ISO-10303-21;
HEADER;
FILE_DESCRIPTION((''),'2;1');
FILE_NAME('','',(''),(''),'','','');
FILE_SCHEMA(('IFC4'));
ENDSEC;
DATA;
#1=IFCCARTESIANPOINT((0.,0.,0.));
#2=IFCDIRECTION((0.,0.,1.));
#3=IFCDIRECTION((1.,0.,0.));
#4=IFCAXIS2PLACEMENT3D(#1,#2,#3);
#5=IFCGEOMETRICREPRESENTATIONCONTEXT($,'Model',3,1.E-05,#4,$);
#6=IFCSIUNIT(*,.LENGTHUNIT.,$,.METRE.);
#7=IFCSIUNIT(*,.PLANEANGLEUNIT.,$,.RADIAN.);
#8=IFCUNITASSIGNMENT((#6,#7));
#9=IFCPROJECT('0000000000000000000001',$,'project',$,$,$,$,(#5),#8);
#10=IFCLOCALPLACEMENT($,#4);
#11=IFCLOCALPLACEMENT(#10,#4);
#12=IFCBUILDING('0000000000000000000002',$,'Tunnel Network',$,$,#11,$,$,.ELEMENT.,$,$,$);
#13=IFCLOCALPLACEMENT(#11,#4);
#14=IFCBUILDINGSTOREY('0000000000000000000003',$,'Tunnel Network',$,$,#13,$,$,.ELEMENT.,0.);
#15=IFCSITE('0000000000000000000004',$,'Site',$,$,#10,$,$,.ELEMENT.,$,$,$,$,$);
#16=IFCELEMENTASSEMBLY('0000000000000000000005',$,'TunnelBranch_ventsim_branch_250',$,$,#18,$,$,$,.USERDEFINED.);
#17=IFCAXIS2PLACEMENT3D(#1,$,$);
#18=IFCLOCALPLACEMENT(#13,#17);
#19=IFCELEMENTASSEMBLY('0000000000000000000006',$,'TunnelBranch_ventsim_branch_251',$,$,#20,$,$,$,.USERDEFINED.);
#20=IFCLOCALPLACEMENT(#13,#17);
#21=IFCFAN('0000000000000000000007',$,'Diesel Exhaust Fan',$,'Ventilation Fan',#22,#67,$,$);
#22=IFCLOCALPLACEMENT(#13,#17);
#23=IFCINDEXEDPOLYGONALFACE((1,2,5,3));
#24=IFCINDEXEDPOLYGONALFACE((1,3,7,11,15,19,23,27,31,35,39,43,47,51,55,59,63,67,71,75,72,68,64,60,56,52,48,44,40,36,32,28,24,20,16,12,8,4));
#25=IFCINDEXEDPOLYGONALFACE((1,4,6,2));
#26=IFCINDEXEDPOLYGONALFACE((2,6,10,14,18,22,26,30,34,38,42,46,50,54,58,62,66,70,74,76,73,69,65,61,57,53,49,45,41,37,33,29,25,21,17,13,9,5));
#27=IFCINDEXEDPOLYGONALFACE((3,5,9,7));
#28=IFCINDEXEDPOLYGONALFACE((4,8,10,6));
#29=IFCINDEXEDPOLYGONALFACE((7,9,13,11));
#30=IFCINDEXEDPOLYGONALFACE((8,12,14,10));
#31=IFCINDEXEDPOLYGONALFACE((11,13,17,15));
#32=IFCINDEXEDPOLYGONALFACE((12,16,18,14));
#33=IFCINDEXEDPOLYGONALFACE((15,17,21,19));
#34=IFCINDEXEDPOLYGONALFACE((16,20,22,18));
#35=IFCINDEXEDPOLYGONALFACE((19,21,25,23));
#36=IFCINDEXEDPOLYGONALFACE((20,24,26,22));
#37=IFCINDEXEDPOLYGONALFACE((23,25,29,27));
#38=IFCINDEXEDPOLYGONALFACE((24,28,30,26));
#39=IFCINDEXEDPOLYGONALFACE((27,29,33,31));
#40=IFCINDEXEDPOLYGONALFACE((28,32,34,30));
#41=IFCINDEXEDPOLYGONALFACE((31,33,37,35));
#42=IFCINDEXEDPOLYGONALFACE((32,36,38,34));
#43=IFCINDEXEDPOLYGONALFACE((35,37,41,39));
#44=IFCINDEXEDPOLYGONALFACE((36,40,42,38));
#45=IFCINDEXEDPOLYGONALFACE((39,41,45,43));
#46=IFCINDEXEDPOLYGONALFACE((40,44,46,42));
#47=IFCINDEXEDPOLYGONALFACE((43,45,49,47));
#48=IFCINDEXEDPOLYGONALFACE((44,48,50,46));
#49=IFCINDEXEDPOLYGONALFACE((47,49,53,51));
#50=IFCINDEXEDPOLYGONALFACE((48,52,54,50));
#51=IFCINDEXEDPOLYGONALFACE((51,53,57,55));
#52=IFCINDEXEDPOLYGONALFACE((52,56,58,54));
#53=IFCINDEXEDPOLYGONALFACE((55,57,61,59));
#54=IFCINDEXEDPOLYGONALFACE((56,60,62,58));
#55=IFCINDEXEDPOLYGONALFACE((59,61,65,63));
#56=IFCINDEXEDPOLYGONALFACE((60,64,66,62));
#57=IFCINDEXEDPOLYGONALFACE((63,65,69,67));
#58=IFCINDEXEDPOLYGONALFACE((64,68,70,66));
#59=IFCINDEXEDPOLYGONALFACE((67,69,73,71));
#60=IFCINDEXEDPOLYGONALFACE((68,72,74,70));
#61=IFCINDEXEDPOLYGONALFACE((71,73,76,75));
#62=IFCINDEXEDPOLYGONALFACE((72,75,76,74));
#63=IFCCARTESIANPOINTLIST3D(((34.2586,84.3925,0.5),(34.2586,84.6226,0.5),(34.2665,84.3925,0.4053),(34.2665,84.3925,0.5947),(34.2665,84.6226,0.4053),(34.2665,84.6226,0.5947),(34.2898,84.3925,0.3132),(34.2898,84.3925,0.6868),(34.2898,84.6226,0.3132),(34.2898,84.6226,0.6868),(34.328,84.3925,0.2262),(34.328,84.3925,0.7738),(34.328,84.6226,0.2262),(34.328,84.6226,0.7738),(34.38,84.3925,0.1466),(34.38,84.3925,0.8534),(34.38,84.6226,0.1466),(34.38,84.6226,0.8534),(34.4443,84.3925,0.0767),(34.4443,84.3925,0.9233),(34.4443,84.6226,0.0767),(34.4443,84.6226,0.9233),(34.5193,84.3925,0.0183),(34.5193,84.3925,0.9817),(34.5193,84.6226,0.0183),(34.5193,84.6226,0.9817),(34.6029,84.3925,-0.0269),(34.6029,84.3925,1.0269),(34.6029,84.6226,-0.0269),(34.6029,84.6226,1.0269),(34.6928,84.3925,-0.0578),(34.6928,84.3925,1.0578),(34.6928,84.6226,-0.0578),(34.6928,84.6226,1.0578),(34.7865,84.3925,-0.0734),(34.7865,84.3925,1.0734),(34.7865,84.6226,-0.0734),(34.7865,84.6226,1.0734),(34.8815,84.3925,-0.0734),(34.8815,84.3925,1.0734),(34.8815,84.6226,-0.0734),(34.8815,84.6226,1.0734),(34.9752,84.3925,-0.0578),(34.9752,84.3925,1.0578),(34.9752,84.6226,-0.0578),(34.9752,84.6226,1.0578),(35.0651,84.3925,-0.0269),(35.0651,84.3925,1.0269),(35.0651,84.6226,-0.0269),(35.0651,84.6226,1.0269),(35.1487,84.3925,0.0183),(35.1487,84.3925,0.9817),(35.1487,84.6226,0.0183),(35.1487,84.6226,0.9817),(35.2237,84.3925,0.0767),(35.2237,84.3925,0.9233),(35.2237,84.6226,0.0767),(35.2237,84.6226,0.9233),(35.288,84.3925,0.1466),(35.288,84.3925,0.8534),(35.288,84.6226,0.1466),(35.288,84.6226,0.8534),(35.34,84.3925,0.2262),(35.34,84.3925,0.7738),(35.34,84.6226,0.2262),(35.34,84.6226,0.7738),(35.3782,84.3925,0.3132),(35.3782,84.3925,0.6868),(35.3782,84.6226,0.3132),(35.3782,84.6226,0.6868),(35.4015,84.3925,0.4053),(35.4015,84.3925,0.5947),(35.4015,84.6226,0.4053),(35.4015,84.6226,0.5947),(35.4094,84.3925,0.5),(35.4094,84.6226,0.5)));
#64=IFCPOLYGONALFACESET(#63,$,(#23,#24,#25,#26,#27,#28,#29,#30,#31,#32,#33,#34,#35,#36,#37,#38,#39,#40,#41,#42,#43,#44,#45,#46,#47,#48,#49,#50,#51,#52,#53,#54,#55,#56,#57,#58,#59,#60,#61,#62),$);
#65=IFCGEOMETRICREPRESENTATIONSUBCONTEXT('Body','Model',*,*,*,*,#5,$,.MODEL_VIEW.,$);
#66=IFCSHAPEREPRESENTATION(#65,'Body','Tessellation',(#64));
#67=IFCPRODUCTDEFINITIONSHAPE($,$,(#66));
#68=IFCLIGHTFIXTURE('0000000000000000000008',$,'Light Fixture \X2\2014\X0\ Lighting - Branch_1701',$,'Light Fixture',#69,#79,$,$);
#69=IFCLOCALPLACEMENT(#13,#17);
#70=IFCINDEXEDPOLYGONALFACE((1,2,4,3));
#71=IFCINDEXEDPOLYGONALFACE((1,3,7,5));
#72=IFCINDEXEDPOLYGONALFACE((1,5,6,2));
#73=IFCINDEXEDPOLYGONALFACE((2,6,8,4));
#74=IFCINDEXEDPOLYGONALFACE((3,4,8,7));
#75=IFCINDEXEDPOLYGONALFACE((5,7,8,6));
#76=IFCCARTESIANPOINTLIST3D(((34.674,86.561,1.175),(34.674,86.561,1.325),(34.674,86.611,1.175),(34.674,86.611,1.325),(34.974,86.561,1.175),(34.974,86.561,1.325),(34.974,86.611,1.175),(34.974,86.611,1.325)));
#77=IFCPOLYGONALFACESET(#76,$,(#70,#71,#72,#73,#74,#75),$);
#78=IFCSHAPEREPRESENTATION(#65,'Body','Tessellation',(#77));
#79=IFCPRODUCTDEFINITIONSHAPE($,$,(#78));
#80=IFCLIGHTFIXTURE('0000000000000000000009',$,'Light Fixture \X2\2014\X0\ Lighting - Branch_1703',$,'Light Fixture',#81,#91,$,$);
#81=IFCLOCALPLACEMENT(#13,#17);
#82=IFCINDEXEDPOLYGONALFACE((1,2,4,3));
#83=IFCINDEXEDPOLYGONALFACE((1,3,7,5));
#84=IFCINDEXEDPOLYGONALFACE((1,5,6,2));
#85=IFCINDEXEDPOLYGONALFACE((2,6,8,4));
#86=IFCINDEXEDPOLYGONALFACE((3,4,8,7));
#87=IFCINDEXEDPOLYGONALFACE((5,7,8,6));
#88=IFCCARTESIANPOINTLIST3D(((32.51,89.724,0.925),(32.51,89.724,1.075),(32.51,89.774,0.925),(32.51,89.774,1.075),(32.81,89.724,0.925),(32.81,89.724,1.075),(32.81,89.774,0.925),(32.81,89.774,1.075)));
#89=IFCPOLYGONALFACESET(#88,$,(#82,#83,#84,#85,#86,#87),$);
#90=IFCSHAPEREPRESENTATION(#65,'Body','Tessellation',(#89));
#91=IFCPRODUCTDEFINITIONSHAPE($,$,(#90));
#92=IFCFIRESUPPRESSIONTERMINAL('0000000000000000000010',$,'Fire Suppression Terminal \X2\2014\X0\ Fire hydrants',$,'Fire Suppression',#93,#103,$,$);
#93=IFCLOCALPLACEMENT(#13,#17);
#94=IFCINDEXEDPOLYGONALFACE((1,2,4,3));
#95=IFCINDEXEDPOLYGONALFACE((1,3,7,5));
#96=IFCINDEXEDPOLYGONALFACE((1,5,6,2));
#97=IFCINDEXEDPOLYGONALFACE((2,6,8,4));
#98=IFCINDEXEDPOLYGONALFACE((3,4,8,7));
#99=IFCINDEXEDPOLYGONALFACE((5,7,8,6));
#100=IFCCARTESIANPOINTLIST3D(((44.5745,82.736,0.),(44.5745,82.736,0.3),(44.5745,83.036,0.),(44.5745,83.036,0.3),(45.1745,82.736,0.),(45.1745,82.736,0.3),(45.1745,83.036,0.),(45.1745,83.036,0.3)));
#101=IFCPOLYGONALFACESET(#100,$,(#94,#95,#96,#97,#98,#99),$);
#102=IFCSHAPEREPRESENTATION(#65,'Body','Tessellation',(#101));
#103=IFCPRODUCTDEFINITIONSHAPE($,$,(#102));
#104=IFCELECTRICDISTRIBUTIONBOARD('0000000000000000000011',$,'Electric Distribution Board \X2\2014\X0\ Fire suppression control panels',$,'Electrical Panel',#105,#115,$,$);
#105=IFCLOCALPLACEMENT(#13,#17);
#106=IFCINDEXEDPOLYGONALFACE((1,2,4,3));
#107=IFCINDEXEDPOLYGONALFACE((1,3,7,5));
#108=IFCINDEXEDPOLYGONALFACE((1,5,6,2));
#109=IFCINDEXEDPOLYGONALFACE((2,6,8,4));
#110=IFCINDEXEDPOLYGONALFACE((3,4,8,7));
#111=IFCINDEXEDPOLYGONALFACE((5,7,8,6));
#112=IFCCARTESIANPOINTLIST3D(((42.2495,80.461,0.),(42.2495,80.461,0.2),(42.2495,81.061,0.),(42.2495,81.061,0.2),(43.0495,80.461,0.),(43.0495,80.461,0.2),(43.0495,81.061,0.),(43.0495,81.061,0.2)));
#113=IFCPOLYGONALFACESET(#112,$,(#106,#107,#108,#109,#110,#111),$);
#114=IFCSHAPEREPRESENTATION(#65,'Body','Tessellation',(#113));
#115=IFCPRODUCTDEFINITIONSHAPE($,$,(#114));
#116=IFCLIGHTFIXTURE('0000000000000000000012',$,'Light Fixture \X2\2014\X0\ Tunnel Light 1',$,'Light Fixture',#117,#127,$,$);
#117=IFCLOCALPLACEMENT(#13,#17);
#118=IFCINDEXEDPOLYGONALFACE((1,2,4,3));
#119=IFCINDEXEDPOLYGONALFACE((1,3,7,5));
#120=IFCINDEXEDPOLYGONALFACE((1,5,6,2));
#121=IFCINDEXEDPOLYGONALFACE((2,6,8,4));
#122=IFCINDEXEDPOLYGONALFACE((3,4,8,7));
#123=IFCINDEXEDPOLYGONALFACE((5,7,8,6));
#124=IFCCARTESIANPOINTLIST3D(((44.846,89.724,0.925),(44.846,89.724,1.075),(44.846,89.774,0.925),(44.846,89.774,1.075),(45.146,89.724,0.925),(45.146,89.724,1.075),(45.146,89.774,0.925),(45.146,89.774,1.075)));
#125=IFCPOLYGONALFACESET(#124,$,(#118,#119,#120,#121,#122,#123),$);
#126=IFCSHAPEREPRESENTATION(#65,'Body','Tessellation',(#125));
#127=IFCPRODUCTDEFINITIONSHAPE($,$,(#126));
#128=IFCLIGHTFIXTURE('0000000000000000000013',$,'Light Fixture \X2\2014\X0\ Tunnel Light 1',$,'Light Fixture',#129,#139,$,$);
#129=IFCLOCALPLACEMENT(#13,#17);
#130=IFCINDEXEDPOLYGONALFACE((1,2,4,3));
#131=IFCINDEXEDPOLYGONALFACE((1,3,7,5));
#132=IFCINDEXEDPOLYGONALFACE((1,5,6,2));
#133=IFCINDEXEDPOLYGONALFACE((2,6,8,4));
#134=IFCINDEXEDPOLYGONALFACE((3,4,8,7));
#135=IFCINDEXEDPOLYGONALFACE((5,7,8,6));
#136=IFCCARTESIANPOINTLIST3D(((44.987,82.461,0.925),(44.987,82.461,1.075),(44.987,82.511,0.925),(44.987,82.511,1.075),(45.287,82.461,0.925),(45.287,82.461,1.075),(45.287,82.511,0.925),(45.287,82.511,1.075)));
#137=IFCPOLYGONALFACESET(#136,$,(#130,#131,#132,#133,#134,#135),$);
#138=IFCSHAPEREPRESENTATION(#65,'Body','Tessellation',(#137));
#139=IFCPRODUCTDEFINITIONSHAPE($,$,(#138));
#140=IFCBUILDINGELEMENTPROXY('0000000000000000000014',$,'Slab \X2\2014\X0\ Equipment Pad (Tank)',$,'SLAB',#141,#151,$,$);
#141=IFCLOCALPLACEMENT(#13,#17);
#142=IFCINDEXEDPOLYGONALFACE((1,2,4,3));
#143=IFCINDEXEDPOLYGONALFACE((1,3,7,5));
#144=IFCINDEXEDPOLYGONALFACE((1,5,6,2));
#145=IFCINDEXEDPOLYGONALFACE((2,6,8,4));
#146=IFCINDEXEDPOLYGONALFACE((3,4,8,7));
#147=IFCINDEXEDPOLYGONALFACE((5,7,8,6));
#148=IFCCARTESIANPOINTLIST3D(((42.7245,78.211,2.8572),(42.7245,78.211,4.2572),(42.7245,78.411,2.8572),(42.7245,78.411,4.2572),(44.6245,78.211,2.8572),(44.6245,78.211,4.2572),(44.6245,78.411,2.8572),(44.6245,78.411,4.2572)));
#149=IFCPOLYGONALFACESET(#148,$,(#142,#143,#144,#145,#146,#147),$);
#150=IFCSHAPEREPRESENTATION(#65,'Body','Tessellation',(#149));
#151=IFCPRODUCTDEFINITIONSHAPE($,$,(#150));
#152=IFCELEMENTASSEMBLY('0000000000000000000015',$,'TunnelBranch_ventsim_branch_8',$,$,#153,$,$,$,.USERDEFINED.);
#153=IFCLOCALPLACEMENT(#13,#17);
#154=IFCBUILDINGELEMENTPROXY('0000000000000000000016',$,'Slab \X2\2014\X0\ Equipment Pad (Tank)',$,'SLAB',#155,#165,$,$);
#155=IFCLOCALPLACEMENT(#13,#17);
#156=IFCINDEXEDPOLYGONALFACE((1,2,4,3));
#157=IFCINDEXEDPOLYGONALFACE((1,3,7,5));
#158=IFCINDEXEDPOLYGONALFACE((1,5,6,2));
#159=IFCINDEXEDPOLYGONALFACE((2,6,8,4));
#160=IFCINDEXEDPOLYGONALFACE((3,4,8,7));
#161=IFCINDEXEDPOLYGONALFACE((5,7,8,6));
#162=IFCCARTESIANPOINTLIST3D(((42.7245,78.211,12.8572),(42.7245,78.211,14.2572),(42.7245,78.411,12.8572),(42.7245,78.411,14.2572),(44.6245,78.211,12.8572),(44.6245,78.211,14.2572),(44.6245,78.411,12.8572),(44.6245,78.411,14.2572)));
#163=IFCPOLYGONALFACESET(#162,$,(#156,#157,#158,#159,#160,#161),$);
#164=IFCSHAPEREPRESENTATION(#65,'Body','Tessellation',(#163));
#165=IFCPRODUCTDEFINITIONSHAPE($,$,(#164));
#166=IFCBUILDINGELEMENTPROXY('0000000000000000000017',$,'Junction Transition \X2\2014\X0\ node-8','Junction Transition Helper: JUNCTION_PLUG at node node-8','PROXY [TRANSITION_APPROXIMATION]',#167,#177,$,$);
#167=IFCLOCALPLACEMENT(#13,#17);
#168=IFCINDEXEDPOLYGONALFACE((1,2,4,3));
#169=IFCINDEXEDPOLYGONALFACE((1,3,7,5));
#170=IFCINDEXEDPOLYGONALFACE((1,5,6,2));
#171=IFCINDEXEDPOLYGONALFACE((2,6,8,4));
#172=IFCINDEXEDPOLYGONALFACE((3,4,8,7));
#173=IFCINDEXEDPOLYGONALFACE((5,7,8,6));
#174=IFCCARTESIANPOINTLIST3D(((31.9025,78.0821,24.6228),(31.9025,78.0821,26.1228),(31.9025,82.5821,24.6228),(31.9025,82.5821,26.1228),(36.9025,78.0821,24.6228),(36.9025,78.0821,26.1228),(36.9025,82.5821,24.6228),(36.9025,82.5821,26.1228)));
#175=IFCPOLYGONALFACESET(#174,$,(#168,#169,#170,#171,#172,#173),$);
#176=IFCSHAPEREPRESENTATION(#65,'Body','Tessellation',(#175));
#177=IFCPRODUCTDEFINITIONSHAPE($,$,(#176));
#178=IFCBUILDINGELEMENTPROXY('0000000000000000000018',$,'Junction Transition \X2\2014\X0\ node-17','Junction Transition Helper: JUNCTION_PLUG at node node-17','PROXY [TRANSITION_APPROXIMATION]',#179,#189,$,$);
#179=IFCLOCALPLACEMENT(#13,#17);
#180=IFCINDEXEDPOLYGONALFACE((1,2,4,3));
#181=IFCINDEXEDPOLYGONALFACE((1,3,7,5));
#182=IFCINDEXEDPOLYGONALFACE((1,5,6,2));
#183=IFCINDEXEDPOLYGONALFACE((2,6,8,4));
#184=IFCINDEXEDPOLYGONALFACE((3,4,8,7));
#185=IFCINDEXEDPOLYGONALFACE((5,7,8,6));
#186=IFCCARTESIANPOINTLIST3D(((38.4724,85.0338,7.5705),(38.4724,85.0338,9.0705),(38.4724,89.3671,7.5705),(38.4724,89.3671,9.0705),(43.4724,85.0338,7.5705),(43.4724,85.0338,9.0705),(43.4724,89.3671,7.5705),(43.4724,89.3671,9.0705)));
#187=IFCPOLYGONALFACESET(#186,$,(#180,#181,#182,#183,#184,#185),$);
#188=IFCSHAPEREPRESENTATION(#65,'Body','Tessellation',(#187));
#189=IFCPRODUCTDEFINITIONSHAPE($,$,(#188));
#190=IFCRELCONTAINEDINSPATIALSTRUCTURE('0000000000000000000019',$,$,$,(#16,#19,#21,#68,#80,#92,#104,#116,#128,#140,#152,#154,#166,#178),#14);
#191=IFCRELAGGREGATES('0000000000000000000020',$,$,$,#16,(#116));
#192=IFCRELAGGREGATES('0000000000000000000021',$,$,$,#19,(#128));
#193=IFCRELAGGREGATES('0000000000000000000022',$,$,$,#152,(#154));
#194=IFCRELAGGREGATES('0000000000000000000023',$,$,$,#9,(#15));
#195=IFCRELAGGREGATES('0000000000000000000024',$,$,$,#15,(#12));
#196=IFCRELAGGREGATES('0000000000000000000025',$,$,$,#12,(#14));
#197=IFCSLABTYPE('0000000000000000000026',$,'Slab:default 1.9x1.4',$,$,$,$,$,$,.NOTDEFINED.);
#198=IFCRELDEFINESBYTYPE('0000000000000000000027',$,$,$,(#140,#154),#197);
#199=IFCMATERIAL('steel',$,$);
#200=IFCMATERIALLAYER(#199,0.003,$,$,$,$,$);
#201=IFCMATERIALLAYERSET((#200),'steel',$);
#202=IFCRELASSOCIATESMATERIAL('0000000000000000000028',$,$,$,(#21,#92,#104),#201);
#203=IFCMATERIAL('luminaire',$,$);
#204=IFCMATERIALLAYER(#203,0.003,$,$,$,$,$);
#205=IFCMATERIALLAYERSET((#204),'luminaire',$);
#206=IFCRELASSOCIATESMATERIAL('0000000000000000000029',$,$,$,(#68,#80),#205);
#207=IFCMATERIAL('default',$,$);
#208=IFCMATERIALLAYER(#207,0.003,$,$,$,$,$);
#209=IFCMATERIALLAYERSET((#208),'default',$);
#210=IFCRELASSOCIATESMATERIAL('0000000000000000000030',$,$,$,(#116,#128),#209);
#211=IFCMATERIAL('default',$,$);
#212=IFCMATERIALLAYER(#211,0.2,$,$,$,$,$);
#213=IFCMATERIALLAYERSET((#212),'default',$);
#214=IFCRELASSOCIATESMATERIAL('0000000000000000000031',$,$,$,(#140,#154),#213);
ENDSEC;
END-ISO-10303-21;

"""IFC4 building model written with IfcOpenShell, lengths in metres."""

from ifc_helpers import new_model, si_unit, frame, origin_with_axes, origin_2d_with_axis, place, context, subcontext, project, spatial, rectangle, circle, extrude, material, layer, layer_set, layer_usage, type_object, element, aggregate, save


model = new_model("IFC4")

# Units and contexts
model_context = context("Model", 3, precision=1e-05, world=origin_with_axes())
body_context = subcontext(model_context, "Body", "Model", "MODEL_VIEW")
ifc_project = project(units=[si_unit("LENGTHUNIT", "METRE"), si_unit("PLANEANGLEUNIT", "RADIAN")], contexts=[model_context])

# Site, building, storey
site_placement = place(None, origin_with_axes())
site = spatial("IfcSite", under=ifc_project, at=site_placement, Name="Site", CompositionType="ELEMENT")
building_placement = place(site_placement, origin_with_axes())
building = spatial("IfcBuilding", under=site, at=building_placement, Name="Tunnel Network", CompositionType="ELEMENT")
storey_placement = place(building_placement, origin_with_axes())
storey = spatial("IfcBuildingStorey", under=building, at=storey_placement, Name="Tunnel Network", CompositionType="ELEMENT", Elevation=0.0)

# Element assemblies
ifc_material_1 = material(Name="default")
ifc_layer_1 = layer(ifc_material_1, 0.003)
ifc_layer_set_1 = layer_set([ifc_layer_1], Name="default")
assembly_1_placement = place(storey_placement, frame((44.996, 89.724, 1.0), z_axis=(0.0, 1.0, 0.0), x_axis=(-1.0, 0.0, 0.0)))
assembly_1 = element("IfcElementAssembly", 1, at=assembly_1_placement, inside=storey, Name="TunnelBranch_ventsim_branch_250", PredefinedType="USERDEFINED")
assembly_2_placement = place(storey_placement, frame((45.137, 82.461, 1.0), z_axis=(0.0, 1.0, 0.0), x_axis=(-1.0, 0.0, 0.0)))
assembly_2 = element("IfcElementAssembly", 2, at=assembly_2_placement, inside=storey, Name="TunnelBranch_ventsim_branch_251", PredefinedType="USERDEFINED")

# Fan
ifc_material_2 = material(Name="steel")
ifc_layer_2 = layer(ifc_material_2, 0.003)
ifc_layer_set_2 = layer_set([ifc_layer_2], Name="steel")
ifc_layer_usage_1 = layer_usage(ifc_layer_set_2, "AXIS2", "POSITIVE", 0.0)
fan_placement = place(storey_placement, frame((34.834, 84.3925, 0.5), z_axis=(0.0, 1.0, 0.0), x_axis=(-1.0, 0.0, 0.0)))
element("IfcFan", 3, at=fan_placement, inside=storey, material=ifc_layer_usage_1, Name="Diesel Exhaust Fan", ObjectType="Ventilation Fan", context=body_context, shape_type="SweptSolid", body=[
    extrude(circle(Radius=0.5754, at=origin_2d_with_axis()), origin_with_axes(), (0.0, 0.0, 1.0), 0.2301),
])

# Light fixtures
ifc_material_3 = material(Name="luminaire")
ifc_layer_3 = layer(ifc_material_3, 0.003)
ifc_layer_set_3 = layer_set([ifc_layer_3], Name="luminaire")
ifc_layer_usage_2 = layer_usage(ifc_layer_set_3, "AXIS2", "POSITIVE", 0.0)
light_fixture_1_placement = place(storey_placement, frame((34.824, 86.561, 1.25), z_axis=(0.0, 1.0, 0.0), x_axis=(-1.0, 0.0, 0.0)))
element("IfcLightFixture", 4, at=light_fixture_1_placement, inside=storey, material=ifc_layer_usage_2, Name="Light Fixture — Lighting - Branch_1701", ObjectType="Light Fixture", context=body_context, shape_type="SweptSolid", body=[
    extrude(rectangle(XDim=0.3, YDim=0.15, at=origin_2d_with_axis()), origin_with_axes(), (0.0, 0.0, 1.0), 0.05),
])
ifc_layer_usage_3 = layer_usage(ifc_layer_set_3, "AXIS2", "POSITIVE", 0.0)
light_fixture_2_placement = place(storey_placement, frame((32.66, 89.724, 1.0), z_axis=(0.0, 1.0, 0.0), x_axis=(-1.0, 0.0, 0.0)))
element("IfcLightFixture", 5, at=light_fixture_2_placement, inside=storey, material=ifc_layer_usage_3, Name="Light Fixture — Lighting - Branch_1703", ObjectType="Light Fixture", context=body_context, shape_type="SweptSolid", body=[
    extrude(rectangle(XDim=0.3, YDim=0.15, at=origin_2d_with_axis()), origin_with_axes(), (0.0, 0.0, 1.0), 0.05),
])

# Fire suppression terminal
ifc_layer_usage_4 = layer_usage(ifc_layer_set_2, "AXIS2", "POSITIVE", 0.0)
fire_suppression_terminal_placement = place(storey_placement, frame((45.1745, 82.886, 0.15), z_axis=(-1.0, 0.0, 0.0), x_axis=(0.0, 1.0, 0.0)))
element("IfcFireSuppressionTerminal", 6, at=fire_suppression_terminal_placement, inside=storey, material=ifc_layer_usage_4, Name="Fire Suppression Terminal — Fire hydrants", ObjectType="Fire Suppression", context=body_context, shape_type="SweptSolid", body=[
    extrude(rectangle(XDim=0.3, YDim=0.3, at=origin_2d_with_axis()), origin_with_axes(), (0.0, 0.0, 1.0), 0.6),
])

# Electric distribution board
ifc_layer_usage_5 = layer_usage(ifc_layer_set_2, "AXIS2", "POSITIVE", 0.0)
electric_distribution_board_1_placement = place(storey_placement, frame((43.0495, 80.761, 0.1), z_axis=(-1.0, 0.0, 0.0), x_axis=(0.0, 1.0, 0.0)))
element("IfcElectricDistributionBoard", 7, at=electric_distribution_board_1_placement, inside=storey, material=ifc_layer_usage_5, Name="Electric Distribution Board — Fire suppression control panels", ObjectType="Electrical Panel", context=body_context, shape_type="SweptSolid", body=[
    extrude(rectangle(XDim=0.6, YDim=0.2, at=origin_2d_with_axis()), origin_with_axes(), (0.0, 0.0, 1.0), 0.8),
])

# Light fixtures
ifc_layer_usage_6 = layer_usage(ifc_layer_set_1, "AXIS2", "POSITIVE", 0.0)
light_fixture_3_placement = place(storey_placement, frame((44.996, 89.724, 1.0), z_axis=(0.0, 1.0, 0.0), x_axis=(-1.0, 0.0, 0.0)))
light_fixture_3 = element("IfcLightFixture", 8, at=light_fixture_3_placement, inside=storey, material=ifc_layer_usage_6, Name="Light Fixture — Tunnel Light 1", ObjectType="Light Fixture", context=body_context, shape_type="SweptSolid", body=[
    extrude(rectangle(XDim=0.3, YDim=0.15, at=origin_2d_with_axis()), origin_with_axes(), (0.0, 0.0, 1.0), 0.05),
])
aggregate(assembly_1, [light_fixture_3])
ifc_layer_usage_7 = layer_usage(ifc_layer_set_1, "AXIS2", "POSITIVE", 0.0)
light_fixture_4_placement = place(storey_placement, frame((45.137, 82.461, 1.0), z_axis=(0.0, 1.0, 0.0), x_axis=(-1.0, 0.0, 0.0)))
light_fixture_4 = element("IfcLightFixture", 9, at=light_fixture_4_placement, inside=storey, material=ifc_layer_usage_7, Name="Light Fixture — Tunnel Light 1", ObjectType="Light Fixture", context=body_context, shape_type="SweptSolid", body=[
    extrude(rectangle(XDim=0.3, YDim=0.15, at=origin_2d_with_axis()), origin_with_axes(), (0.0, 0.0, 1.0), 0.05),
])
aggregate(assembly_2, [light_fixture_4])

# Building element proxy
ifc_material_4 = material(Name="default")
ifc_layer_4 = layer(ifc_material_4, 0.2)
ifc_layer_set_4 = layer_set([ifc_layer_4], Name="default")
ifc_layer_usage_8 = layer_usage(ifc_layer_set_4, "AXIS3", "POSITIVE", 0.0)
slab_type = type_object("IfcSlabType", Name="Slab:default 1.9x1.4")
proxy_1_placement = place(storey_placement, frame((43.6745, 78.411, 3.5572), z_axis=(0.0, 1.0, 0.0), x_axis=(-1.0, 0.0, 0.0)))
element("IfcBuildingElementProxy", 10, at=proxy_1_placement, inside=storey, type_object=slab_type, material=ifc_layer_usage_8, Name="Slab — Equipment Pad (Tank)", ObjectType="SLAB", context=body_context, shape_type="SweptSolid", body=[
    extrude(rectangle(XDim=1.9, YDim=1.4, at=origin_2d_with_axis()), frame((0.0, 0.0, 0.0), z_axis=(0.0, 0.0, -1.0), x_axis=(1.0, 0.0, 0.0)), (0.0, 0.0, 1.0), 0.2),
])

# Element assembly, building element proxy
assembly_3_placement = place(storey_placement, frame((47.6745, 80.761, 43.5572), z_axis=(0.0, 1.0, 0.0), x_axis=(-1.0, 0.0, 0.0)))
assembly_3 = element("IfcElementAssembly", 11, at=assembly_3_placement, inside=storey, Name="TunnelBranch_ventsim_branch_8", PredefinedType="USERDEFINED")
ifc_layer_usage_9 = layer_usage(ifc_layer_set_4, "AXIS3", "POSITIVE", 0.0)
proxy_2_placement = place(storey_placement, frame((43.6745, 78.411, 13.5572), z_axis=(0.0, 1.0, 0.0), x_axis=(-1.0, 0.0, 0.0)))
proxy_2 = element("IfcBuildingElementProxy", 12, at=proxy_2_placement, inside=storey, type_object=slab_type, material=ifc_layer_usage_9, Name="Slab — Equipment Pad (Tank)", ObjectType="SLAB", context=body_context, shape_type="SweptSolid", body=[
    extrude(rectangle(XDim=1.9, YDim=1.4, at=origin_2d_with_axis()), frame((0.0, 0.0, 0.0), z_axis=(0.0, 0.0, -1.0), x_axis=(1.0, 0.0, 0.0)), (0.0, 0.0, 1.0), 0.2),
])

# Building element proxies
proxy_3_placement = place(storey_placement, frame((34.4025, 80.3321, 24.6228), z_axis=(0.0, 0.0, 1.0), x_axis=(1.0, 0.0, 0.0)))
element("IfcBuildingElementProxy", 13, at=proxy_3_placement, inside=storey, Name="Junction Transition — node-8", Description="Junction Transition Helper: JUNCTION_PLUG at node node-8", ObjectType="PROXY [TRANSITION_APPROXIMATION]", context=body_context, shape_type="SweptSolid", body=[
    extrude(rectangle(XDim=5.0, YDim=4.5, at=origin_2d_with_axis()), origin_with_axes(), (0.0, 0.0, 1.0), 1.5),
])
proxy_4_placement = place(storey_placement, frame((40.9724, 87.2004, 7.5705), z_axis=(0.0, 0.0, 1.0), x_axis=(1.0, 0.0, 0.0)))
element("IfcBuildingElementProxy", 14, at=proxy_4_placement, inside=storey, Name="Junction Transition — node-17", Description="Junction Transition Helper: JUNCTION_PLUG at node node-17", ObjectType="PROXY [TRANSITION_APPROXIMATION]", context=body_context, shape_type="SweptSolid", body=[
    extrude(rectangle(XDim=5.0, YDim=4.3333, at=origin_2d_with_axis()), origin_with_axes(), (0.0, 0.0, 1.0), 1.5),
])

aggregate(assembly_3, [proxy_2])

save(model, "model.ifc")
